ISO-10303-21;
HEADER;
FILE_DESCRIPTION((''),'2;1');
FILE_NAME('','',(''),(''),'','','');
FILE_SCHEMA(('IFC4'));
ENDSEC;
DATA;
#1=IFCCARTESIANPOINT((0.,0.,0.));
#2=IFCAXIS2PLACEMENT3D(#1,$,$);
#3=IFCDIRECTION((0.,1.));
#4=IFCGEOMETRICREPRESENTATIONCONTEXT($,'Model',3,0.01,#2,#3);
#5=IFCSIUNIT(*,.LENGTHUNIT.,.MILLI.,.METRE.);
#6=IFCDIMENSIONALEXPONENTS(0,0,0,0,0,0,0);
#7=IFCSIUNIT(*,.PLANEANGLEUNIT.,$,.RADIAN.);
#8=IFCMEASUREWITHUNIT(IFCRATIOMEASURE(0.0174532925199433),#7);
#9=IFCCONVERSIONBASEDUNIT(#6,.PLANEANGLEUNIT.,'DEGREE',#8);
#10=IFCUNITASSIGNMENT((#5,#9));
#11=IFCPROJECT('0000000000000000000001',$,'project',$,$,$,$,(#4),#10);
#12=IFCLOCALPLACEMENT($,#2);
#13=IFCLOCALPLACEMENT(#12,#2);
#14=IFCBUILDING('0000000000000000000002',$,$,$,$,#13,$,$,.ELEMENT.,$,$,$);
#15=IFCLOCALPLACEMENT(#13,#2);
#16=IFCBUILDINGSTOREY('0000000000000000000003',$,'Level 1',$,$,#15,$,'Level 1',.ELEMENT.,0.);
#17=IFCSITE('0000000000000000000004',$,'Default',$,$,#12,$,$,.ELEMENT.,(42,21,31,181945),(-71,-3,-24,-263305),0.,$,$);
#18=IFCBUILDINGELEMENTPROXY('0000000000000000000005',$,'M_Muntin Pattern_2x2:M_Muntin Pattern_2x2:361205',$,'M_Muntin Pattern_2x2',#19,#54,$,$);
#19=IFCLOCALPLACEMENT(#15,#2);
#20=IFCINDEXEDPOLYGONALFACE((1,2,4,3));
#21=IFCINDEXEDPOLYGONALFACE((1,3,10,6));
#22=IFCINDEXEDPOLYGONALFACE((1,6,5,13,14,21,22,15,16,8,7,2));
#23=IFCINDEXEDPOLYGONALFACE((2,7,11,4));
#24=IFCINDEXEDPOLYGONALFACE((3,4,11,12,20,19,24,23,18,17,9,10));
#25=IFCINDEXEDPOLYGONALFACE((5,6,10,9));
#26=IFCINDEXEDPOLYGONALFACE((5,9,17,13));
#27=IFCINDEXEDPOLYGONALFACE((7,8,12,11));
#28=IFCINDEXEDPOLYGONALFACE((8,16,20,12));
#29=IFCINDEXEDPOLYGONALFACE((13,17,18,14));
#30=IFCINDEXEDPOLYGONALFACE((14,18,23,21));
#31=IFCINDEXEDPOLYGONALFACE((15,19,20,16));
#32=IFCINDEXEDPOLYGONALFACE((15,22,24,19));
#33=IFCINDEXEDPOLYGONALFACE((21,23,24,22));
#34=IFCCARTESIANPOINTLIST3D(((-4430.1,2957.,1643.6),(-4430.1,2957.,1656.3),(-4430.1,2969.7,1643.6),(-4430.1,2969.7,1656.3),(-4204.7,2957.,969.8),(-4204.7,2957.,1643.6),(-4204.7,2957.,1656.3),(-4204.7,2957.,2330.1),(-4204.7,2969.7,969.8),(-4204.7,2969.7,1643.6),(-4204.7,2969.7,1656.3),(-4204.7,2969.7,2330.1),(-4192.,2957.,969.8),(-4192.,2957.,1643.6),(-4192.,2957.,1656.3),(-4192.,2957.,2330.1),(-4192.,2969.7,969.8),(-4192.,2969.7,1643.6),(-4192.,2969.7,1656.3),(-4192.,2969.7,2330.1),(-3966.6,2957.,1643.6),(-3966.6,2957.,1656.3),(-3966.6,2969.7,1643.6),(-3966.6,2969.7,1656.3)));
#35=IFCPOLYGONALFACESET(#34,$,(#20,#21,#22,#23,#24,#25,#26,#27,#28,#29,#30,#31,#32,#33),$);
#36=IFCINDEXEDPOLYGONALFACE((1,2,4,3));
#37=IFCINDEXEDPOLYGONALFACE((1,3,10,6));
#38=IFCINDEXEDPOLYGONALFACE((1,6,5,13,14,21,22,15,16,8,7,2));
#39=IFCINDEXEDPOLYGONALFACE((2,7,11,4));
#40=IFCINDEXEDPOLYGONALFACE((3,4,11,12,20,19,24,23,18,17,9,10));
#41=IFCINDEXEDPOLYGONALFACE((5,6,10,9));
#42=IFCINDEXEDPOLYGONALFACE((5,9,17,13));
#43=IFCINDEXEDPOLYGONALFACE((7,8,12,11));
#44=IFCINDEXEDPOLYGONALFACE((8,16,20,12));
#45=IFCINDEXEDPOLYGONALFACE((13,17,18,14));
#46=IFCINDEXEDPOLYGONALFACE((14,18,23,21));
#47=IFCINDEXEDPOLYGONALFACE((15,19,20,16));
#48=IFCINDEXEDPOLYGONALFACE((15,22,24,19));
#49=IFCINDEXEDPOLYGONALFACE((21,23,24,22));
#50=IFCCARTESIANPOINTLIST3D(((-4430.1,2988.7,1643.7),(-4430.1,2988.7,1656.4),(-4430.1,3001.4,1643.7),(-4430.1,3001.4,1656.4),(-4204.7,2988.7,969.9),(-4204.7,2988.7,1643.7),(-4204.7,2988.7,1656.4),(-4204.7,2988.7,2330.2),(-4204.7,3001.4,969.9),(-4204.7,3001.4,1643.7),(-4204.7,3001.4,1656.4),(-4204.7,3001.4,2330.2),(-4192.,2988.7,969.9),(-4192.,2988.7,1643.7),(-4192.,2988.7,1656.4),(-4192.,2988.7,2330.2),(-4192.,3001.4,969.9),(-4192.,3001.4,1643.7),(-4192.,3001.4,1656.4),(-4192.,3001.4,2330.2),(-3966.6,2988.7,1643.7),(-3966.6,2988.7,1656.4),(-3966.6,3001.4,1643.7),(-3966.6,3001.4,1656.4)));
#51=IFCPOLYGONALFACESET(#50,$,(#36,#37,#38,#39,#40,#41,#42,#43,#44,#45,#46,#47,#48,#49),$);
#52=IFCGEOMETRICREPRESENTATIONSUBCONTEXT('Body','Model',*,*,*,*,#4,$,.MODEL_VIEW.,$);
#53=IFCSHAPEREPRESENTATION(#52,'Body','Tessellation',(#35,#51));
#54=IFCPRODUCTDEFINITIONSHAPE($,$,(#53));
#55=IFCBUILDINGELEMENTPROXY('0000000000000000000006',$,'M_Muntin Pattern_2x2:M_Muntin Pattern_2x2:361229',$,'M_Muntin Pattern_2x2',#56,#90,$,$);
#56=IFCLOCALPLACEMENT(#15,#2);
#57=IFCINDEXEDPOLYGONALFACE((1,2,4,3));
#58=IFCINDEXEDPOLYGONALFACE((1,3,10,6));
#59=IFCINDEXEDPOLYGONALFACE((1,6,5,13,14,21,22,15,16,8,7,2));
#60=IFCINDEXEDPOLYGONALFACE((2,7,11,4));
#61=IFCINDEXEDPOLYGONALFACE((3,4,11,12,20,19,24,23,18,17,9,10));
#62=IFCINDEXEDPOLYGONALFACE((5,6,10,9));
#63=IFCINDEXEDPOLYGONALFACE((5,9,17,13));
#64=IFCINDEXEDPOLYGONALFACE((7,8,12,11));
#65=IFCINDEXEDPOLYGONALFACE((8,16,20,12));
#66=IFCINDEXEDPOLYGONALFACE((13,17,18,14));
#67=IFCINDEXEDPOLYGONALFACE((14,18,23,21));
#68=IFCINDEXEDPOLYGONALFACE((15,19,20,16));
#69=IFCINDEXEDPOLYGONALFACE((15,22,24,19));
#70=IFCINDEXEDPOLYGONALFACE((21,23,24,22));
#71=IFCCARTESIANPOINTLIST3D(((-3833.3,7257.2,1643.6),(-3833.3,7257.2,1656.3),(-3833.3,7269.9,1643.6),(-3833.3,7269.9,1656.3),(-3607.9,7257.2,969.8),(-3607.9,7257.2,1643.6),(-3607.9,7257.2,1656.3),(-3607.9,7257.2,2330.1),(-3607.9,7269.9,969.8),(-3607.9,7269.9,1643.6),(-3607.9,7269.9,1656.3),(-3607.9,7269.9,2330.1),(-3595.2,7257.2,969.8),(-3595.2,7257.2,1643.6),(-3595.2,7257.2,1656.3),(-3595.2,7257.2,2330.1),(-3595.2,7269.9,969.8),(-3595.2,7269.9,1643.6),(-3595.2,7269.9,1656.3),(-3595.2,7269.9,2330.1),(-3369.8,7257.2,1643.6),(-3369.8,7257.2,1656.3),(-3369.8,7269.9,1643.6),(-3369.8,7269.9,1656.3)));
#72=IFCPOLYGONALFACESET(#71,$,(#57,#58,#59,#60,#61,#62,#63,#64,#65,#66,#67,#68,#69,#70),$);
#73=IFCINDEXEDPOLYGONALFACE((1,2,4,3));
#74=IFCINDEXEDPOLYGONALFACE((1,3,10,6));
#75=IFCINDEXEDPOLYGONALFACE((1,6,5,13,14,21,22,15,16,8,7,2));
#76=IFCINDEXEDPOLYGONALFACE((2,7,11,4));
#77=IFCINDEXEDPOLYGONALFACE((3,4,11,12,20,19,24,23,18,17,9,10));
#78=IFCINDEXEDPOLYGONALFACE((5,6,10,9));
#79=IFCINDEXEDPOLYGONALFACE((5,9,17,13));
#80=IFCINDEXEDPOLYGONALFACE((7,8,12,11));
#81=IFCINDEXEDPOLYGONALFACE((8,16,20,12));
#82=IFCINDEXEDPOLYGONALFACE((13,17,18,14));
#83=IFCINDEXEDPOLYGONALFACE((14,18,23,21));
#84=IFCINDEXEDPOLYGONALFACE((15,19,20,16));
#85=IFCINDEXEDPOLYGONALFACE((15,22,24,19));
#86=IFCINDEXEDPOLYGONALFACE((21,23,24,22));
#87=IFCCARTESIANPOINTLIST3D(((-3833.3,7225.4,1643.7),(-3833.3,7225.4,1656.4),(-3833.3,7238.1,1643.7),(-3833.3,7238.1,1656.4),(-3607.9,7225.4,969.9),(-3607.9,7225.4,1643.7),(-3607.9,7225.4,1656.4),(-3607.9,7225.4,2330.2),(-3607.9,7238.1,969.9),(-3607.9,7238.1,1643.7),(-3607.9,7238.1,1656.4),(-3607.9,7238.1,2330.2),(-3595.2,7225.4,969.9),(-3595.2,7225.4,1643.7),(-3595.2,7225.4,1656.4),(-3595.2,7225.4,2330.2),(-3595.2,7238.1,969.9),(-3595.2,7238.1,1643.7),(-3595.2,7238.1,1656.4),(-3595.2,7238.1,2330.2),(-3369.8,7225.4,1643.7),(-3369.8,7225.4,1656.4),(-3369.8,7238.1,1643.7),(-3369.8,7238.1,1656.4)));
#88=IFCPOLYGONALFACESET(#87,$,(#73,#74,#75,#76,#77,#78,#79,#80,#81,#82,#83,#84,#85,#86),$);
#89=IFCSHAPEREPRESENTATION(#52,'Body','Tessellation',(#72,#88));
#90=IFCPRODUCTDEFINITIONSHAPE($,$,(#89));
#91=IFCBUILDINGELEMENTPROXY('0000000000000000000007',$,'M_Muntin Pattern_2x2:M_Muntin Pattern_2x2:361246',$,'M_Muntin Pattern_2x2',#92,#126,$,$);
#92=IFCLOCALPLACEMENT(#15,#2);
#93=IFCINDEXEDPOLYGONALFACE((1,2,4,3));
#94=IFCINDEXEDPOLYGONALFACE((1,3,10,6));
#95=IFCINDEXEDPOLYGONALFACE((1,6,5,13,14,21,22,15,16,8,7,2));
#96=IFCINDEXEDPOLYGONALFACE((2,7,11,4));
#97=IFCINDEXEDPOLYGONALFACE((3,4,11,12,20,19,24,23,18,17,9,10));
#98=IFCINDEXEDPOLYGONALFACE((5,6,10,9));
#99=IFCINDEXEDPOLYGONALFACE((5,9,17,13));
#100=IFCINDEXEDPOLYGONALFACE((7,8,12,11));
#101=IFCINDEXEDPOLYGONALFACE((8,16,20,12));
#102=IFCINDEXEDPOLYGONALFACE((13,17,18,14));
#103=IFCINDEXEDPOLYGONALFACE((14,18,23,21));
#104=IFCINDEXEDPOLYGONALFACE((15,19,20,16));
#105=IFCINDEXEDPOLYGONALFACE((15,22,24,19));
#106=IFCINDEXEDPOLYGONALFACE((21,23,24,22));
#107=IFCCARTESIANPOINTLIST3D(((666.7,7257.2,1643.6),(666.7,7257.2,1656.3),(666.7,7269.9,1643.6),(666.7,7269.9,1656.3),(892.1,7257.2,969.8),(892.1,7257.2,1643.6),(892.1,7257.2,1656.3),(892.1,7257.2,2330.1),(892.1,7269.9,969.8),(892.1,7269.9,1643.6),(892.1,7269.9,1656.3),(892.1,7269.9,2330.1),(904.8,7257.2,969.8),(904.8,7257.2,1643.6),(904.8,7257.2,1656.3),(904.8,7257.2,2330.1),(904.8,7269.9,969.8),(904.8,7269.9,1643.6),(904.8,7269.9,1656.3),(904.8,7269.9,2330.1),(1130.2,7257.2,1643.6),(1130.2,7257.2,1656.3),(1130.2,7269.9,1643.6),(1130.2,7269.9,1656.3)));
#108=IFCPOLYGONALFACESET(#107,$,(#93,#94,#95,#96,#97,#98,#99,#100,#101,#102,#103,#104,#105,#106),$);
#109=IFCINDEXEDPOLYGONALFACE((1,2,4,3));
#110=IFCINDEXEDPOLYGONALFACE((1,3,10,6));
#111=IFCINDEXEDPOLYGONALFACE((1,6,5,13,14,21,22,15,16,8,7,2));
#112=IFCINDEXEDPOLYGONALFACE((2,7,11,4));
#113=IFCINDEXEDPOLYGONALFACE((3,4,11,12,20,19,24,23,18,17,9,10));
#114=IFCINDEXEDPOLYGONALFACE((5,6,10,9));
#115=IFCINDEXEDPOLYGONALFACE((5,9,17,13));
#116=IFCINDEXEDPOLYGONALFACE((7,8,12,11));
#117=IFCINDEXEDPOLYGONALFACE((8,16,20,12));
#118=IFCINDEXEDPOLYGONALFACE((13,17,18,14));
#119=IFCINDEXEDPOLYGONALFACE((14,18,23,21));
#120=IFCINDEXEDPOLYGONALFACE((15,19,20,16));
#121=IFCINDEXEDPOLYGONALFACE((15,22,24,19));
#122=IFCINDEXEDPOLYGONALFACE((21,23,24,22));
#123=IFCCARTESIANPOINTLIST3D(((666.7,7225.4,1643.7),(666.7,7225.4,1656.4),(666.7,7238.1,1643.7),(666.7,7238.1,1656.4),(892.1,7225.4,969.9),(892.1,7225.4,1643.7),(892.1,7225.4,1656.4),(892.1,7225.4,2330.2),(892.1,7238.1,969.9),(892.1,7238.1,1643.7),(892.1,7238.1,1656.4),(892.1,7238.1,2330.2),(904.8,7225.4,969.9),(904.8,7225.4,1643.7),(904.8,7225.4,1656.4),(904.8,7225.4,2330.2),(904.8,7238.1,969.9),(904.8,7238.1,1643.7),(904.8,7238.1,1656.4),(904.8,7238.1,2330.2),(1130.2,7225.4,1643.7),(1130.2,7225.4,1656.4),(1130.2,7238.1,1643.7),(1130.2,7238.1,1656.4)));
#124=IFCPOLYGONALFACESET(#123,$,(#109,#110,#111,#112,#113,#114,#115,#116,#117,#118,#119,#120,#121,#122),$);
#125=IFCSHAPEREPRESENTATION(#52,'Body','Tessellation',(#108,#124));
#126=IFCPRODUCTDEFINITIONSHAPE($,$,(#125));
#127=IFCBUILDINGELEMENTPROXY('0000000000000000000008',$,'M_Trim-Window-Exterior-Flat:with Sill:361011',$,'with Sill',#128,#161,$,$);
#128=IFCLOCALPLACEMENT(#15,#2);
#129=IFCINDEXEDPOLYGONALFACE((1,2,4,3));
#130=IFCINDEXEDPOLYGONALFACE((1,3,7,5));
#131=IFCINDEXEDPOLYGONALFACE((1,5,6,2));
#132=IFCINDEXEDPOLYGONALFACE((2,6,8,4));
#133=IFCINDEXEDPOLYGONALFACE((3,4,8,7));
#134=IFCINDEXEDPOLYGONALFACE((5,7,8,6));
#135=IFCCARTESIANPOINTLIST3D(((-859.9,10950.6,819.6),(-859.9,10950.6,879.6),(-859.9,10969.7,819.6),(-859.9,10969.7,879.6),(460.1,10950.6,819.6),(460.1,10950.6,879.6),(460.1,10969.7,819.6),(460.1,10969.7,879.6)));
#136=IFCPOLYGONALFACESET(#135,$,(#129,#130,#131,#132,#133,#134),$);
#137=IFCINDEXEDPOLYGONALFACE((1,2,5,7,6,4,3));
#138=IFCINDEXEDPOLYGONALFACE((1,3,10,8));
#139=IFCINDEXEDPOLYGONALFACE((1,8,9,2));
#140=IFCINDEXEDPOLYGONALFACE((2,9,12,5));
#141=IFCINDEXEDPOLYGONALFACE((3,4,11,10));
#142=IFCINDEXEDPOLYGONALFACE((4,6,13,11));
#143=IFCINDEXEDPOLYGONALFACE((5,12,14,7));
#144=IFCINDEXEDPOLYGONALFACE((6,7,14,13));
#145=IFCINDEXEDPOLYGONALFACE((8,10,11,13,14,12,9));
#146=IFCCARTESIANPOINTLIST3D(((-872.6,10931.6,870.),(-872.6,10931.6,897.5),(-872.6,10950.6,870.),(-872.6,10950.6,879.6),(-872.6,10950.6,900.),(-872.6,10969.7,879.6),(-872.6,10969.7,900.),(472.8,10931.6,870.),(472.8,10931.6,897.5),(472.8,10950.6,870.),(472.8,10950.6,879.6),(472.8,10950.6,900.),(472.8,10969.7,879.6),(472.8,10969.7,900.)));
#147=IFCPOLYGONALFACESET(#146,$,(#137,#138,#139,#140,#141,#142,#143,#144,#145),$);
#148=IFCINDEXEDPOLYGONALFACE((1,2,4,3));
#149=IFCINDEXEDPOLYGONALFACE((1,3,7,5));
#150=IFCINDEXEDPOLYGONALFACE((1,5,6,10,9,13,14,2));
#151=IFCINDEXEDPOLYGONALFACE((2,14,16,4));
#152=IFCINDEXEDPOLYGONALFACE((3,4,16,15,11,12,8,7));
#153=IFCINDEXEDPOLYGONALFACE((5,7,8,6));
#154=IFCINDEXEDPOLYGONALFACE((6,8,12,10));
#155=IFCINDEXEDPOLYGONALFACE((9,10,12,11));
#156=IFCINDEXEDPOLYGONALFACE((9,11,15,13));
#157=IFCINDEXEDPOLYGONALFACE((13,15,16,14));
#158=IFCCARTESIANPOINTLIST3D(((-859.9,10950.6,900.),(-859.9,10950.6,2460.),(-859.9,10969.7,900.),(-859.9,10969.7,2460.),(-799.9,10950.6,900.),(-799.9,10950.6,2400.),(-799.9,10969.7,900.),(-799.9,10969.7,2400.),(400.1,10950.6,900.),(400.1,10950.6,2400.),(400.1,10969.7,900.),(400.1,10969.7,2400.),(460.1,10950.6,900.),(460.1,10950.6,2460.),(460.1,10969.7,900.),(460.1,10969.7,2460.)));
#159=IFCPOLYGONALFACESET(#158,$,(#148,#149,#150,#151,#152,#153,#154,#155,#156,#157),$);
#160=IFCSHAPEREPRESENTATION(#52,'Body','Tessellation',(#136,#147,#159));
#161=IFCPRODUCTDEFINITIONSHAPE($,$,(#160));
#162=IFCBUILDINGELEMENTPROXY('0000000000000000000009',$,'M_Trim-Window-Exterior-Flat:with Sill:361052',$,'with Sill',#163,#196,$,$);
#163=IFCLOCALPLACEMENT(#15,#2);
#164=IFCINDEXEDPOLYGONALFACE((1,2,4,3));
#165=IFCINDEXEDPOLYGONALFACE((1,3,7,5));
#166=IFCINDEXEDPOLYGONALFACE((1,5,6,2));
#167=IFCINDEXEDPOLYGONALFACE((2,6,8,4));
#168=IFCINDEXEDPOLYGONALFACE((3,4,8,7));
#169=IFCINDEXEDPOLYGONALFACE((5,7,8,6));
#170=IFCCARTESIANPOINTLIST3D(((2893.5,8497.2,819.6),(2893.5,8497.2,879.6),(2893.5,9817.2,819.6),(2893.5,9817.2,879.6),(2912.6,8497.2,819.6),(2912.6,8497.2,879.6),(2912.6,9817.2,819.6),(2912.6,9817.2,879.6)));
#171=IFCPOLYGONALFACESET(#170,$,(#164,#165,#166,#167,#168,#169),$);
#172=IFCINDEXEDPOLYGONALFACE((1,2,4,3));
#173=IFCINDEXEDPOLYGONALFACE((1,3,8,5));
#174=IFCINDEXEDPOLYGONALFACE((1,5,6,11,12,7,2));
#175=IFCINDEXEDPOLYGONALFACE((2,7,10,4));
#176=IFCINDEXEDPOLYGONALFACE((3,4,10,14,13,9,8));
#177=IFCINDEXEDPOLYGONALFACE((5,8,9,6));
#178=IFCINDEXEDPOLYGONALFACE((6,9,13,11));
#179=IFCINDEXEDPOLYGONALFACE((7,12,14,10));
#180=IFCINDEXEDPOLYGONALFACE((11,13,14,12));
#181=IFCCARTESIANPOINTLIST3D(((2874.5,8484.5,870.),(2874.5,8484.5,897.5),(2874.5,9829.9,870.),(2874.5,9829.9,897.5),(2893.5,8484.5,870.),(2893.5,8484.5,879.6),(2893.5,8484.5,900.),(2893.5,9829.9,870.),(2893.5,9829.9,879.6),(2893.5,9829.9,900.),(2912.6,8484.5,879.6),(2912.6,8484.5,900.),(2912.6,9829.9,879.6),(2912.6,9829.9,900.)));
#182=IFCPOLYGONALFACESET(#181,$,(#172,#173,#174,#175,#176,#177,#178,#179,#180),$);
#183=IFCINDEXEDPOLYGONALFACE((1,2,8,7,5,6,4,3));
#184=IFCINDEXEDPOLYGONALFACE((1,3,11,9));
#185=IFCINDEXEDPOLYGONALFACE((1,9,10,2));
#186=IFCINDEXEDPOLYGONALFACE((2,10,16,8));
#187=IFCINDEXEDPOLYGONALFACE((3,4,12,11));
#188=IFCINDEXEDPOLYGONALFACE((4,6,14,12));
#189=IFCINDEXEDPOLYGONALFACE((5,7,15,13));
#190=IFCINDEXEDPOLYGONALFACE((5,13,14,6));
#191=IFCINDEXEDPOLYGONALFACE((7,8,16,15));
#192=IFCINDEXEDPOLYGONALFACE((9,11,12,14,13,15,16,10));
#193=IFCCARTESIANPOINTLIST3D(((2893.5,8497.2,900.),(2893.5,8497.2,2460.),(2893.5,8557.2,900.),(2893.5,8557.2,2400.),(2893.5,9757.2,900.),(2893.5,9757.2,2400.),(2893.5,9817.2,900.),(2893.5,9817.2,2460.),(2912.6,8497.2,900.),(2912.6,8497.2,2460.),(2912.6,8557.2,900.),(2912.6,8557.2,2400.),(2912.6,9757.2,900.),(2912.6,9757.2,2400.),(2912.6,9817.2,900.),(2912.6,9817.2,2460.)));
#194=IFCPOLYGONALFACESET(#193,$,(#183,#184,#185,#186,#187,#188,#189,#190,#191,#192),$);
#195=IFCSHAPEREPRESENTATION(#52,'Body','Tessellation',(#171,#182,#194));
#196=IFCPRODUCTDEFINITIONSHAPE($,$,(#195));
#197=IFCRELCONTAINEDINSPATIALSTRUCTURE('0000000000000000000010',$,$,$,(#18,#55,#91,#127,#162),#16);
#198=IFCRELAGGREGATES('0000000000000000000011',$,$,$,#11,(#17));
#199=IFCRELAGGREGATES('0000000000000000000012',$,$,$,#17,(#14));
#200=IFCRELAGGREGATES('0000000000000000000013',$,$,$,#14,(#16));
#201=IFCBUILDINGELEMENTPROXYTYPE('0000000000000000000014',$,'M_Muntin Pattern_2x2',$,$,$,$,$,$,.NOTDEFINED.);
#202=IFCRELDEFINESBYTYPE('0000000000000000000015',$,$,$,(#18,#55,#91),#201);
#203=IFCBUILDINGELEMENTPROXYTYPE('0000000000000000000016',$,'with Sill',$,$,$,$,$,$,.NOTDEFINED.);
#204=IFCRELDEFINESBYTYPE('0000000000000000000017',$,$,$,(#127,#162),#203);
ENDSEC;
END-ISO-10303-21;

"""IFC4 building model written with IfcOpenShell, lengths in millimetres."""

from ifc_helpers import new_model, entity, si_unit, converted_unit, direction, frame, frame_2d, origin, place, context, subcontext, project, spatial, polyline, rectangle, outline, extrude, source, transform, mapped, type_object, type_shapes, element, save


model = new_model("IFC4")

# Units and contexts
model_context = context("Model", 3, precision=0.01, world=origin(), true_north=direction((0.0, 1.0)))
body_context = subcontext(model_context, "Body", "Model", "MODEL_VIEW")
ifc_project = project(units=[si_unit("LENGTHUNIT", "METRE", prefix="MILLI"), converted_unit("PLANEANGLEUNIT", "DEGREE", entity("IfcRatioMeasure", 0.0174532925199433), si_unit("PLANEANGLEUNIT", "RADIAN"), dimensions=[0, 0, 0, 0, 0, 0, 0])], contexts=[model_context])

# Site, building, storey
site_placement = place(None, origin())
site = spatial("IfcSite", under=ifc_project, at=site_placement, Name="Default", CompositionType="ELEMENT", RefLatitude=(42, 21, 31, 181945), RefLongitude=(-71, -3, -24, -263305), RefElevation=0.0)
building_placement = place(site_placement, origin())
building = spatial("IfcBuilding", under=site, at=building_placement, CompositionType="ELEMENT")
storey_placement = place(building_placement, origin())
storey = spatial("IfcBuildingStorey", under=building, at=storey_placement, Name="Level 1", LongName="Level 1", CompositionType="ELEMENT", Elevation=0.0)

# Building element proxies
building_element_proxy_type_1 = type_object("IfcBuildingElementProxyType", Name="M_Muntin Pattern_2x2", PredefinedType="NOTDEFINED")
shared_shape_1 = source(origin(), body_context, "Body", "SweptSolid", [
    extrude(outline(polyline([(6.4, -6.4), (680.1, -6.4), (680.1, 6.3), (6.4, 6.3), (6.4, 231.7), (-6.3, 231.7), (-6.3, 6.3), (-680.2, 6.3), (-680.2, -6.4), (-6.3, -6.4), (-6.3, -231.7), (6.4, -231.7), (6.4, -6.4)])), frame((0.0, -22.2, 680.1), z_axis=(0.0, 1.0, 0.0), x_axis=(0.0, 0.0, 1.0)), (0.0, 0.0, 1.0), 12.7),
    extrude(outline(polyline([(6.4, -6.4), (680.1, -6.4), (680.1, 6.3), (6.4, 6.3), (6.4, 231.7), (-6.3, 231.7), (-6.3, 6.3), (-680.2, 6.3), (-680.2, -6.4), (-6.3, -6.4), (-6.3, -231.7), (6.4, -231.7), (6.4, -6.4)])), frame((0.0, 9.5, 680.2), z_axis=(0.0, 1.0, 0.0), x_axis=(0.0, 0.0, 1.0)), (0.0, 0.0, 1.0), 12.7),
])
type_shapes(building_element_proxy_type_1, [shared_shape_1])
proxy_1_placement = place(storey_placement, frame((-4198.4, 2979.2, 969.9)))
element("IfcBuildingElementProxy", 1, at=proxy_1_placement, inside=storey, type_object=building_element_proxy_type_1, Name="M_Muntin Pattern_2x2:M_Muntin Pattern_2x2:361205", ObjectType="M_Muntin Pattern_2x2", context=body_context, shape_type="MappedRepresentation", body=[
    mapped(shared_shape_1, transform((0.0, 0.0, 0.0), scale=1.0)),
])
for number, where, z_axis, x_axis, name in (
    (2, (-3601.5, 7247.6, 969.9), (0.0, 0.0, 1.0), (-1.0, 0.0, 0.0), "M_Muntin Pattern_2x2:M_Muntin Pattern_2x2:361229"),
    (3, (898.5, 7247.6, 969.9), (0.0, 0.0, 1.0), (-1.0, 0.0, 0.0), "M_Muntin Pattern_2x2:M_Muntin Pattern_2x2:361246"),
):
    element("IfcBuildingElementProxy", number, at=place(storey_placement, frame(where, z_axis=z_axis, x_axis=x_axis)), inside=storey, type_object=building_element_proxy_type_1, Name=name, ObjectType="M_Muntin Pattern_2x2", context=body_context, shape_type="MappedRepresentation", body=[
        mapped(shared_shape_1, transform((0.0, 0.0, 0.0), scale=1.0)),
    ])
building_element_proxy_type_2 = type_object("IfcBuildingElementProxyType", Name="with Sill", PredefinedType="NOTDEFINED")
shared_shape_2 = source(origin(), body_context, "Body", "SweptSolid", [
    extrude(rectangle(XDim=1320.0, YDim=60.0, at=frame_2d((0.0, 0.0), x_axis=(1.0, 0.0))), frame((0.0, -1550.4, 0.0), z_axis=(0.0, 0.0, 1.0), x_axis=(-1.0, 0.0, 0.0)), (0.0, 0.0, 1.0), 19.1),
    extrude(outline(polyline([(-19.0, -15.2), (0.0, -15.2), (0.0, -5.7), (19.0, -5.7), (19.0, 14.8), (0.0, 14.8), (-19.0, 12.3), (-19.0, -15.2)])), frame((-672.7, -1514.8, 19.0), z_axis=(1.0, 0.0, 0.0), x_axis=(0.0, 0.0, -1.0)), (0.0, 0.0, 1.0), 1345.4),
    extrude(outline(polyline([(-795.0, -660.0), (765.0, -660.0), (765.0, -600.0), (-735.0, -600.0), (-735.0, 600.0), (765.0, 600.0), (765.0, 660.0), (-795.0, 660.0), (-795.0, -660.0)])), frame((0.0, -735.0, 0.0), z_axis=(0.0, 0.0, 1.0), x_axis=(0.0, -1.0, 0.0)), (0.0, 0.0, 1.0), 19.1),
])
type_shapes(building_element_proxy_type_2, [shared_shape_2])
for number, where, z_axis, x_axis, name in (
    (4, (-199.9, 10969.7, 2400.0), (0.0, -1.0, 0.0), (1.0, 0.0, 0.0), "M_Trim-Window-Exterior-Flat:with Sill:361011"),
    (5, (2912.6, 9157.2, 2400.0), (-1.0, 0.0, 0.0), (0.0, -1.0, 0.0), "M_Trim-Window-Exterior-Flat:with Sill:361052"),
):
    element("IfcBuildingElementProxy", number, at=place(storey_placement, frame(where, z_axis=z_axis, x_axis=x_axis)), inside=storey, type_object=building_element_proxy_type_2, Name=name, ObjectType="with Sill", context=body_context, shape_type="MappedRepresentation", body=[
        mapped(shared_shape_2, transform((0.0, 0.0, 0.0), scale=1.0)),
    ])

save(model, "model.ifc")
